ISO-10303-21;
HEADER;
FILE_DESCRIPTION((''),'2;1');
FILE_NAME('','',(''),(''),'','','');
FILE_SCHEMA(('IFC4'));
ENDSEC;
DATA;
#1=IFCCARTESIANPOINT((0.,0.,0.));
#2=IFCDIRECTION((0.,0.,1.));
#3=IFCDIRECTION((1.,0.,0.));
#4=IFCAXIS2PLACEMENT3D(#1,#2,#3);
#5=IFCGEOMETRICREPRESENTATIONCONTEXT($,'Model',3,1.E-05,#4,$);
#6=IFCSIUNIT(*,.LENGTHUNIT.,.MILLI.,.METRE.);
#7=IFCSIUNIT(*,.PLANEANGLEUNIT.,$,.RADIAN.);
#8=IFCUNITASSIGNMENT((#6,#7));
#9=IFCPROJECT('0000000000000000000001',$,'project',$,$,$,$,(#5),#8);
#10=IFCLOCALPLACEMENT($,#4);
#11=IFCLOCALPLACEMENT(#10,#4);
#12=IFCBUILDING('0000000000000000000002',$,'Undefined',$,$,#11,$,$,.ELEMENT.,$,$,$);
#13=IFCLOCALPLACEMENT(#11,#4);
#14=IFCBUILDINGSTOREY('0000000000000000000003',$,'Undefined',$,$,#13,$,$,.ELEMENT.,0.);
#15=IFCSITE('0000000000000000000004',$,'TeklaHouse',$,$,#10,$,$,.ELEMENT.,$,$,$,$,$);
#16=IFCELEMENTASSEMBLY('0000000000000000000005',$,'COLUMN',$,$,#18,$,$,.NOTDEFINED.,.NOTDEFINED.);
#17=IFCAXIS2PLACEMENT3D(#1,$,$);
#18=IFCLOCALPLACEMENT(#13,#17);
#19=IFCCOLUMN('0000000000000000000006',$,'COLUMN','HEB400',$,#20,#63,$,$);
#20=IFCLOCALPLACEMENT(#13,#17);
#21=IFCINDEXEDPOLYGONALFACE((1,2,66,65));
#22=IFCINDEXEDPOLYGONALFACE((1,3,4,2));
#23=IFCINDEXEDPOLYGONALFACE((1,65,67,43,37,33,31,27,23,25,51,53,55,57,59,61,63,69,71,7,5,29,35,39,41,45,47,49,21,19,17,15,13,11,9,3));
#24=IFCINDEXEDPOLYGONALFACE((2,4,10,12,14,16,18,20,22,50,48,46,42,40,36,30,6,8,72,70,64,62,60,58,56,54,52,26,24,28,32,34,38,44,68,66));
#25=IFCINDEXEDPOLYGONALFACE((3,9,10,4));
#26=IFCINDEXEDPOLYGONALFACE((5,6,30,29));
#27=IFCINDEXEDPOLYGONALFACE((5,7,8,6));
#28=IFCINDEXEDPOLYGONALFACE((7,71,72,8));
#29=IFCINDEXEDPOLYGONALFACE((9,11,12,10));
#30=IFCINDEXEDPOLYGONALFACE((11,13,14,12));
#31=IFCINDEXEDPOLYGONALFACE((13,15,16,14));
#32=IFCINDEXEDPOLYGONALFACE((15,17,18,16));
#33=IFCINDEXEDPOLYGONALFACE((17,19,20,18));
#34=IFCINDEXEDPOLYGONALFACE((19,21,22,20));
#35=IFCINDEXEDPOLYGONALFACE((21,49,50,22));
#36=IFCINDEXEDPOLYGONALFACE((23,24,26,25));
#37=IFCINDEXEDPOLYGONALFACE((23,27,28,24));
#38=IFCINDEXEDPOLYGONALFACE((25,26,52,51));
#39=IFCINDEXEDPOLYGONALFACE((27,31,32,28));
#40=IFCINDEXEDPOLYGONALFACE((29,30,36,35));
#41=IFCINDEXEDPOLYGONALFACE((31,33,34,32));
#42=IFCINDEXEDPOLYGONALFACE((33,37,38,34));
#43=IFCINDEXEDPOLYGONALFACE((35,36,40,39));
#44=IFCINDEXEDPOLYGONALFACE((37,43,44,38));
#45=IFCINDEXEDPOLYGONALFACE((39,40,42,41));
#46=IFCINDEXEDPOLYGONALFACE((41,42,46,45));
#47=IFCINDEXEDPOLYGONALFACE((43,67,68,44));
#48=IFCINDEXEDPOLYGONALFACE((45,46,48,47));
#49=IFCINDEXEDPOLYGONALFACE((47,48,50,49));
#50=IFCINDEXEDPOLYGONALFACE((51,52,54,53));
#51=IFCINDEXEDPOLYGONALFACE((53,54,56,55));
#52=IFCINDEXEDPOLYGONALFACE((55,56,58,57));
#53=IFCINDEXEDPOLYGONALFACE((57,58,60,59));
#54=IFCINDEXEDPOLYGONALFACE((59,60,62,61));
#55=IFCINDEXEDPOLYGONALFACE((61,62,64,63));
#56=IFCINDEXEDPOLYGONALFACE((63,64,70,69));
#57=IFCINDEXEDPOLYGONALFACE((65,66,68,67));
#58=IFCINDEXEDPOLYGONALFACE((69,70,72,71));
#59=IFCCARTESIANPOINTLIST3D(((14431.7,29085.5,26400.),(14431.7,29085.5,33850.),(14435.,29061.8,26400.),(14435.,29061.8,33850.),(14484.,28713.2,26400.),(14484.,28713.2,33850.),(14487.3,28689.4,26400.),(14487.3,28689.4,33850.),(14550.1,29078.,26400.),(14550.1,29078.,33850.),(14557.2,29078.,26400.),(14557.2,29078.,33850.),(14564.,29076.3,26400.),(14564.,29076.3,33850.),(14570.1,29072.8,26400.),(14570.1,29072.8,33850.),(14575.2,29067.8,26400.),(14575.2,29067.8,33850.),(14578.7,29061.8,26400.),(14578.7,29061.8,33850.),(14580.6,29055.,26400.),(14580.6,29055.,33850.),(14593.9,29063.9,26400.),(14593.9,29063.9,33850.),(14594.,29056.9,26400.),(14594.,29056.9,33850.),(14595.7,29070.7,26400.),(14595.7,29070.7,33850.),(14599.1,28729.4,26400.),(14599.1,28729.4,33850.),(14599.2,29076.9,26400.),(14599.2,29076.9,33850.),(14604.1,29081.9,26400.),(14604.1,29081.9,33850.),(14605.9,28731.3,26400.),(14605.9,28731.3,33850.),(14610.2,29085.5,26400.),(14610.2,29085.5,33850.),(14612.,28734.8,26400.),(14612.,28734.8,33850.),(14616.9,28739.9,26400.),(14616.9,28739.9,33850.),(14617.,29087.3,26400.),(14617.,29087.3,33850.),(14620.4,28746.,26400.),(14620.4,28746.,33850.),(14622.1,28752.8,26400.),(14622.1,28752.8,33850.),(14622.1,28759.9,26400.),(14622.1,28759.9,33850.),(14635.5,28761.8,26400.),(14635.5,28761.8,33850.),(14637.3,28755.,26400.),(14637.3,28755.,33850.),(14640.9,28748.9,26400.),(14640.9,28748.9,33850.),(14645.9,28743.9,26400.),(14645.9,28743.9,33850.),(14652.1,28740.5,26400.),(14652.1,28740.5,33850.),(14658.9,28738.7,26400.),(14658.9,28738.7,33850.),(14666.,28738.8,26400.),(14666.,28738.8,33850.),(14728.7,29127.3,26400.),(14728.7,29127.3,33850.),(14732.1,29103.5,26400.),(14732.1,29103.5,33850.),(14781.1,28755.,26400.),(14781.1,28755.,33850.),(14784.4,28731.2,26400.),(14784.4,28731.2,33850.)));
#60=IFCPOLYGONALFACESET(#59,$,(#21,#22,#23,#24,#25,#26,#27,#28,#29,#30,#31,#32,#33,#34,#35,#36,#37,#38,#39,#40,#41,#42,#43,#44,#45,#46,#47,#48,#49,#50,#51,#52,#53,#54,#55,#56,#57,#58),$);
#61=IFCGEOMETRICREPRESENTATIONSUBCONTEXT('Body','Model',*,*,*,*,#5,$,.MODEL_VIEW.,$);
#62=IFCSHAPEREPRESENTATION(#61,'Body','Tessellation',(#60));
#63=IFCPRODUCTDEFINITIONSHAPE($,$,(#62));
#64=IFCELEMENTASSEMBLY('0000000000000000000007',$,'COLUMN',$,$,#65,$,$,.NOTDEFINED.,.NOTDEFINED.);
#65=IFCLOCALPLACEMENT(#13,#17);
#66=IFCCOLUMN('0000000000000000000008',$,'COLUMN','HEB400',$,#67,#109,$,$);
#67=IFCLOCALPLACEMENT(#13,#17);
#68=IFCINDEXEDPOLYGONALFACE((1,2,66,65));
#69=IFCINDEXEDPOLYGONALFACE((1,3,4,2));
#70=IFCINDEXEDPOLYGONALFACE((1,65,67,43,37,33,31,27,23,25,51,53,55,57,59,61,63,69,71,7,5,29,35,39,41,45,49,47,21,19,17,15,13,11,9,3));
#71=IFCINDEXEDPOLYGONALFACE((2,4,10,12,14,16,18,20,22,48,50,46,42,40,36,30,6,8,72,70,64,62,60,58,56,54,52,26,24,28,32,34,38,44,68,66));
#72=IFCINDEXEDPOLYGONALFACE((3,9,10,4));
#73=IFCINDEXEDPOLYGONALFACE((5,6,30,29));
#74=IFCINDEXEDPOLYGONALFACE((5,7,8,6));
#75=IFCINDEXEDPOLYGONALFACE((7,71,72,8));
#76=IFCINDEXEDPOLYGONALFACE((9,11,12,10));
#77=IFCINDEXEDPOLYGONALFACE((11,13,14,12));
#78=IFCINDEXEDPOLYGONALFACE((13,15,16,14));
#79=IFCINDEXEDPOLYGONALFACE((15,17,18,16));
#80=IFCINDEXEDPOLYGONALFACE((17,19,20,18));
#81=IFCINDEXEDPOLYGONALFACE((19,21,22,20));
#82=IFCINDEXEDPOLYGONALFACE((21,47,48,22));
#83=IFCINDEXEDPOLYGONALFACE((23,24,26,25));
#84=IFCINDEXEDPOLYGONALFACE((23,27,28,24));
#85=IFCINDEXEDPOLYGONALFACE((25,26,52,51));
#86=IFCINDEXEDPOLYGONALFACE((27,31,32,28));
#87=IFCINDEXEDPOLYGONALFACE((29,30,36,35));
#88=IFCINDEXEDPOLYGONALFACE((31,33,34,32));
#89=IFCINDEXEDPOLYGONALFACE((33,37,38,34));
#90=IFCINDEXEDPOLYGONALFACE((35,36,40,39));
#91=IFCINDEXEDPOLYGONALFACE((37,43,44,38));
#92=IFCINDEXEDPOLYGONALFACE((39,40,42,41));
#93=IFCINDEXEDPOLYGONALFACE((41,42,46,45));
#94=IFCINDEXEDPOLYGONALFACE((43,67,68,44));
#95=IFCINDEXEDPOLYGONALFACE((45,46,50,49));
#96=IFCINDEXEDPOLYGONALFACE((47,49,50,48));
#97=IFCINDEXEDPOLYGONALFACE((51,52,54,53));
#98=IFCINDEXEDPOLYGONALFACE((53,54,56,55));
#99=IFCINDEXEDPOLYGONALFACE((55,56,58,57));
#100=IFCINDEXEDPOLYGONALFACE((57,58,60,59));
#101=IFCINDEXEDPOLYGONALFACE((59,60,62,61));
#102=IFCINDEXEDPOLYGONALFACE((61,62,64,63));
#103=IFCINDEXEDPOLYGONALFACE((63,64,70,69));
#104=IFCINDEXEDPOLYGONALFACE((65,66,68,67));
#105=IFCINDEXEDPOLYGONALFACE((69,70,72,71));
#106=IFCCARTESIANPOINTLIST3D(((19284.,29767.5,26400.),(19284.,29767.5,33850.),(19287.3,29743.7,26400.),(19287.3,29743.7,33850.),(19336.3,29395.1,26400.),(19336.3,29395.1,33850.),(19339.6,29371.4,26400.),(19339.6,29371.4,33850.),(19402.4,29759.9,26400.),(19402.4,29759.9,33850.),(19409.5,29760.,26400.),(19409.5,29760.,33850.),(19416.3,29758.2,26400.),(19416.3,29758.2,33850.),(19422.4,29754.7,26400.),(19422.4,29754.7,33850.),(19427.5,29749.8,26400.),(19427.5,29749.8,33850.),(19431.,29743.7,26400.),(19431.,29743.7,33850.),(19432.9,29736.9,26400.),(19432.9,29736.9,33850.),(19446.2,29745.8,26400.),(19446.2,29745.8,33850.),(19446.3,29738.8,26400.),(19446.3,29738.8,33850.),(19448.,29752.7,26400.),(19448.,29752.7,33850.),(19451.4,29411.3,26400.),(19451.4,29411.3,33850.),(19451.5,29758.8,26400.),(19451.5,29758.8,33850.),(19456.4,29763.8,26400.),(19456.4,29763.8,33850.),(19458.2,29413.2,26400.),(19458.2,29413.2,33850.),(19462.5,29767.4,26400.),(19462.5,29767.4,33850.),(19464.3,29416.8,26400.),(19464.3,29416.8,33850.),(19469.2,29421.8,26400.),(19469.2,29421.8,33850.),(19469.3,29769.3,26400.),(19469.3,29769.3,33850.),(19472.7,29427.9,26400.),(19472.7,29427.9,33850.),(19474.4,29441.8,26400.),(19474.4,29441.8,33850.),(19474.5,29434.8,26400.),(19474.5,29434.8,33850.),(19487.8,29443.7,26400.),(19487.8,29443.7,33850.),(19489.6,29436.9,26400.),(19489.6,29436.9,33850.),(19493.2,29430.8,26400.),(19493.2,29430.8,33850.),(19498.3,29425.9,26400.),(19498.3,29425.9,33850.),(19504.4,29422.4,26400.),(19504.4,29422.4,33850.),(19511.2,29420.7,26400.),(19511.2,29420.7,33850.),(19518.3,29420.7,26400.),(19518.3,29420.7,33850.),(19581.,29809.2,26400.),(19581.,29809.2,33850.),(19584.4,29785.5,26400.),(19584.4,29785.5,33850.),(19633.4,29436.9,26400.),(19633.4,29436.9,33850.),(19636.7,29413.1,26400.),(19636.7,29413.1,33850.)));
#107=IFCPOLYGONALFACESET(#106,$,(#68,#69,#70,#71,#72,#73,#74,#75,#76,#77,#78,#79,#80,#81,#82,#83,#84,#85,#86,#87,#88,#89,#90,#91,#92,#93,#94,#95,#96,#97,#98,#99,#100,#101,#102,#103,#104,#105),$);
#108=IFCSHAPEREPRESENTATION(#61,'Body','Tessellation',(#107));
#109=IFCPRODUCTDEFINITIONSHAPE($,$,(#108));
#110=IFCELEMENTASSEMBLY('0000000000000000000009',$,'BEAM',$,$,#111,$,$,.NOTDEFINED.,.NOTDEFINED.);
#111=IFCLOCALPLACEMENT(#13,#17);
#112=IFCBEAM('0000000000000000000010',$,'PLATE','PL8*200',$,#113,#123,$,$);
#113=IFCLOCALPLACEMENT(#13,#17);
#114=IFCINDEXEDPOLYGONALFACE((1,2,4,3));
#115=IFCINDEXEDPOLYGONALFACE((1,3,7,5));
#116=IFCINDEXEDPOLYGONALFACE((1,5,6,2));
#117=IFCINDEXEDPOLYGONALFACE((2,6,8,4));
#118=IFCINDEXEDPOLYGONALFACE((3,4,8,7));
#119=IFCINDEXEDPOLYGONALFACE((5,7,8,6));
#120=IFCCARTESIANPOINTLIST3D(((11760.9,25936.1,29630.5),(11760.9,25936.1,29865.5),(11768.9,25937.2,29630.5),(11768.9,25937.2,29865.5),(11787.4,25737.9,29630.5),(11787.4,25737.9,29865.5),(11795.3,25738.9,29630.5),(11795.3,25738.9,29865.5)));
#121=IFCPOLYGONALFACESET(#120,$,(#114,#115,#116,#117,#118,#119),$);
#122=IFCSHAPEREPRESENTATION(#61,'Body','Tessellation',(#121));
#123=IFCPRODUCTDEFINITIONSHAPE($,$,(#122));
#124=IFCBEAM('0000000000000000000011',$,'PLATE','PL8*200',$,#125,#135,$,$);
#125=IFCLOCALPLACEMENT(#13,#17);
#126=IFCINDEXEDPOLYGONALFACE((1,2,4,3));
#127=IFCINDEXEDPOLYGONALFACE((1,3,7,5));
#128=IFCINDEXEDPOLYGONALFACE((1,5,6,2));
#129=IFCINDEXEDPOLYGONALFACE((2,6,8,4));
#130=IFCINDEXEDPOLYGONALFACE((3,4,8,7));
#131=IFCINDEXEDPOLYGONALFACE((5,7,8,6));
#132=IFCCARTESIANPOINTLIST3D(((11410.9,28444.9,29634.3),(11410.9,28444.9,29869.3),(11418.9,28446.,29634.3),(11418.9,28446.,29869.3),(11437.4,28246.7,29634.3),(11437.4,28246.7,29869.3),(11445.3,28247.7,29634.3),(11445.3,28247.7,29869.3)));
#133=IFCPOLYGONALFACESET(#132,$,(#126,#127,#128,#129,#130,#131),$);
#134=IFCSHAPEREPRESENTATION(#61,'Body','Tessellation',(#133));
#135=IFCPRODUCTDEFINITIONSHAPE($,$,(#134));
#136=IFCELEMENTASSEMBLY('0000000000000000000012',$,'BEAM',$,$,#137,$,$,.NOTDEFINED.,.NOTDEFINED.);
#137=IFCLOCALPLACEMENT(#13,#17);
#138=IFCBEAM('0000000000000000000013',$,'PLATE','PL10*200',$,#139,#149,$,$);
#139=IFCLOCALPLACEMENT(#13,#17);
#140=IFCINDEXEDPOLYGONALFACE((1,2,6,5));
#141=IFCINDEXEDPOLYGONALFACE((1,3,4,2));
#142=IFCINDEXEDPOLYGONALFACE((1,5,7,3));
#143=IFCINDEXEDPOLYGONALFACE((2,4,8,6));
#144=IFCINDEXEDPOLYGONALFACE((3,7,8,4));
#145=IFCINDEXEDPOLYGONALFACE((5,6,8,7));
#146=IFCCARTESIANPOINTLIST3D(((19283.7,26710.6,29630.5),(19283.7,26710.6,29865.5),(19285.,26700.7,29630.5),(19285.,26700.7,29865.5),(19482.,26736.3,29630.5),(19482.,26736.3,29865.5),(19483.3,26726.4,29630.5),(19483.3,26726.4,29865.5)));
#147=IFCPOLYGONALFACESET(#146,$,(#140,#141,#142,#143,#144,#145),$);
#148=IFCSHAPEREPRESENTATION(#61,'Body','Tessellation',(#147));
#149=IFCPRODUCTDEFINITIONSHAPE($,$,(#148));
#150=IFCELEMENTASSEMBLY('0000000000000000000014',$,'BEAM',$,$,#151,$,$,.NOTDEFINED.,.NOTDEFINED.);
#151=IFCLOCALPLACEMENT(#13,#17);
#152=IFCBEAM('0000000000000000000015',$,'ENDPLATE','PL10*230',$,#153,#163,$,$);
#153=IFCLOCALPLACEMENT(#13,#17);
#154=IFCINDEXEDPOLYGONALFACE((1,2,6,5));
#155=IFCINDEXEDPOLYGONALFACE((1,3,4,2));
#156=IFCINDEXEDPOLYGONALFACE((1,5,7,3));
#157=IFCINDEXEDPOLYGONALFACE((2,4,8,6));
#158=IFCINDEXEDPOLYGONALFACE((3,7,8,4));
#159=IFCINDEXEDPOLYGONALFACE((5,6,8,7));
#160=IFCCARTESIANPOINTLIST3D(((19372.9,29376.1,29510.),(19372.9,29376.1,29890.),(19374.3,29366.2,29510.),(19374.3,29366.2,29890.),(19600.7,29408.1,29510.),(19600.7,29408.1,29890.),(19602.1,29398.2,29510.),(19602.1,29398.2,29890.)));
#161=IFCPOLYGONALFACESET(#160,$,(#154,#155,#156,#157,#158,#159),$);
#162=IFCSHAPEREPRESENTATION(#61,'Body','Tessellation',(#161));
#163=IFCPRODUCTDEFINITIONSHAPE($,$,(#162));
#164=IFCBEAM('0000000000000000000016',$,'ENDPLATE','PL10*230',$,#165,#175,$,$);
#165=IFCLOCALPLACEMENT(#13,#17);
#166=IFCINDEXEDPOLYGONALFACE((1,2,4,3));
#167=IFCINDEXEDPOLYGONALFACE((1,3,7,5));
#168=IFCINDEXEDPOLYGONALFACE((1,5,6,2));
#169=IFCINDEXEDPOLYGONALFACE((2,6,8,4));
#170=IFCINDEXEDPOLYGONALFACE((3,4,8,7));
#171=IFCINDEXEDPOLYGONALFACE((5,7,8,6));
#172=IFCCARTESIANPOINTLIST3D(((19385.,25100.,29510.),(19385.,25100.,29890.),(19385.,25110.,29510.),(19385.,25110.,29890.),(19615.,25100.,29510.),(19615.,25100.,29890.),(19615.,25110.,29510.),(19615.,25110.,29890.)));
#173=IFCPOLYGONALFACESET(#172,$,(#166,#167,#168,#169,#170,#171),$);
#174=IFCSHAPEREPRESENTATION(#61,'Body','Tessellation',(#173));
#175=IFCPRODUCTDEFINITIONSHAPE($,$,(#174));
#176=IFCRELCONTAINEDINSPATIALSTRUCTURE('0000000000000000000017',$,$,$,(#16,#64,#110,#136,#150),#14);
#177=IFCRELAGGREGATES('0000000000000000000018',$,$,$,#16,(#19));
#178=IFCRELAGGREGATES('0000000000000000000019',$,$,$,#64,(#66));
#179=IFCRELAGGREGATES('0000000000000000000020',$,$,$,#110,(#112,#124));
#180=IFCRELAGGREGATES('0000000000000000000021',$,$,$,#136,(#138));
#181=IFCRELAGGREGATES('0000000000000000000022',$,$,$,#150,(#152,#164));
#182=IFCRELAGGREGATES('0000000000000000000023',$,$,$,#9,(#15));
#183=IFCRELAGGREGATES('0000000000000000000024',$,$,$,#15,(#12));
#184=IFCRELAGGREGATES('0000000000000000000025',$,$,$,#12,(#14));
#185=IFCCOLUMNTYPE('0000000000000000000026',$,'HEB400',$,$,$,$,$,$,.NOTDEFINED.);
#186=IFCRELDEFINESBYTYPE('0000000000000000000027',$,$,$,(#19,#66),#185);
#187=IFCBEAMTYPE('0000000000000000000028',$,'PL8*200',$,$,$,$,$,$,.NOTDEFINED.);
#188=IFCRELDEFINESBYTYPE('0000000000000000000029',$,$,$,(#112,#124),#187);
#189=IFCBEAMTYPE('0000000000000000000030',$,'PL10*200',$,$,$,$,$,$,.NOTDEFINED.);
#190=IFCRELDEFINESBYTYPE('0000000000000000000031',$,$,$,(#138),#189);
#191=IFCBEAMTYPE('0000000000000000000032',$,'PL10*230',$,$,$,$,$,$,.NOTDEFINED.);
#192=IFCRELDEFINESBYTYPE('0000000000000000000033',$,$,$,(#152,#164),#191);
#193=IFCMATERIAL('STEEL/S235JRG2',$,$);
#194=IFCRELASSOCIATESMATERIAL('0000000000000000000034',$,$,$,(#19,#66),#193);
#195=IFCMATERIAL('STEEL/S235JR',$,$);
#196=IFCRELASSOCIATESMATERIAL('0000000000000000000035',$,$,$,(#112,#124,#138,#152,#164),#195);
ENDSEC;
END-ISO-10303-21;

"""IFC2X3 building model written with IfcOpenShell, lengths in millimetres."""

from ifc_helpers import new_model, si_unit, frame, origin_with_axes, origin_2d_with_axis, place, context, subcontext, project, spatial, rectangle, i_section, extrude, material, type_object, element, aggregate, save


model = new_model("IFC2X3")

# Units and contexts
model_context = context("Model", 3, precision=1e-05, world=origin_with_axes())
body_context = subcontext(model_context, "Body", "Model", "MODEL_VIEW")
ifc_project = project(units=[si_unit("LENGTHUNIT", "METRE", prefix="MILLI"), si_unit("PLANEANGLEUNIT", "RADIAN")], contexts=[model_context])

# Site, building, storey
site_placement = place(None, origin_with_axes())
site = spatial("IfcSite", under=ifc_project, at=site_placement, Name="TeklaHouse", CompositionType="ELEMENT")
building_placement = place(site_placement, origin_with_axes())
building = spatial("IfcBuilding", under=site, at=building_placement, Name="Undefined", CompositionType="ELEMENT")
storey_placement = place(building_placement, origin_with_axes())
storey = spatial("IfcBuildingStorey", under=building, at=storey_placement, Name="Undefined", CompositionType="ELEMENT", Elevation=0.0)

# Element assemblies, columns
assembly_1_placement = place(storey_placement, origin_with_axes())
assembly_1 = element("IfcElementAssembly", 1, at=assembly_1_placement, inside=storey, Name="COLUMN", AssemblyPlace="NOTDEFINED", PredefinedType="NOTDEFINED")
ifc_material_1 = material(Name="STEEL/S235JRG2")
column_type = type_object("IfcColumnType", Name="HEB400", PredefinedType="NOTDEFINED")
column_1_placement = place(assembly_1_placement, frame((14608.0, 28908.4, 26400.0), z_axis=(0.0, 0.0, 1.0), x_axis=(-0.139174, 0.990268, 0.0)))
column_1 = element("IfcColumn", 2, at=column_1_placement, type_object=column_type, material=ifc_material_1, Name="COLUMN", Description="HEB400", context=body_context, shape_type="SweptSolid", body=[
    extrude(i_section(OverallWidth=300.0, OverallDepth=400.0, WebThickness=13.5, FlangeThickness=24.0, FilletRadius=27.0, at=origin_2d_with_axis()), frame((0.0, 0.0, 7450.0), z_axis=(0.0, 0.0, -1.0), x_axis=(0.0, 1.0, 0.0)), (0.0, 0.0, 1.0), 7450.0),
])
aggregate(assembly_1, [column_1])
assembly_2_placement = place(storey_placement, origin_with_axes())
assembly_2 = element("IfcElementAssembly", 3, at=assembly_2_placement, inside=storey, Name="COLUMN", AssemblyPlace="NOTDEFINED", PredefinedType="NOTDEFINED")
column_2_placement = place(assembly_2_placement, frame((19460.3, 29590.3, 26400.0), z_axis=(0.0, 0.0, 1.0), x_axis=(-0.139174, 0.990268, 0.0)))
column_2 = element("IfcColumn", 4, at=column_2_placement, type_object=column_type, material=ifc_material_1, Name="COLUMN", Description="HEB400", context=body_context, shape_type="SweptSolid", body=[
    extrude(i_section(OverallWidth=300.0, OverallDepth=400.0, WebThickness=13.5, FlangeThickness=24.0, FilletRadius=27.0, at=origin_2d_with_axis()), frame((0.0, 0.0, 7450.0), z_axis=(0.0, 0.0, -1.0), x_axis=(0.0, 1.0, 0.0)), (0.0, 0.0, 1.0), 7450.0),
])

# Element assembly, beams
assembly_3_placement = place(storey_placement, origin_with_axes())
assembly_3 = element("IfcElementAssembly", 5, at=assembly_3_placement, inside=storey, Name="BEAM", AssemblyPlace="NOTDEFINED", PredefinedType="NOTDEFINED")
ifc_material_2 = material(Name="STEEL/S235JR")
beam_type_1 = type_object("IfcBeamType", Name="PL8*200", PredefinedType="NOTDEFINED")
beam_1_placement = place(assembly_3_placement, frame((11778.1, 25837.5, 29630.5), z_axis=(0.132256, -0.991216, 0.0), x_axis=(0.0, 0.0, 1.0)))
beam_1 = element("IfcBeam", 6, at=beam_1_placement, type_object=beam_type_1, material=ifc_material_2, Name="PLATE", Description="PL8*200", context=body_context, shape_type="SweptSolid", body=[
    extrude(rectangle(XDim=8.0, YDim=200.0, at=origin_2d_with_axis()), frame((235.0, 0.0, 0.0), z_axis=(-1.0, 0.0, 0.0), x_axis=(0.0, -1.0, 0.0)), (0.0, 0.0, 1.0), 235.0),
])
beam_2_placement = place(assembly_3_placement, frame((11428.1, 28346.3, 29634.3), z_axis=(-0.132256, 0.991216, 0.0), x_axis=(0.0, 0.0, 1.0)))
beam_2 = element("IfcBeam", 7, at=beam_2_placement, type_object=beam_type_1, material=ifc_material_2, Name="PLATE", Description="PL8*200", context=body_context, shape_type="SweptSolid", body=[
    extrude(rectangle(XDim=8.0, YDim=200.0, at=origin_2d_with_axis()), frame((235.0, 0.0, 0.0), z_axis=(-1.0, 0.0, 0.0), x_axis=(0.0, -1.0, 0.0)), (0.0, 0.0, 1.0), 235.0),
])

# Element assembly, beam
assembly_4_placement = place(storey_placement, origin_with_axes())
assembly_4 = element("IfcElementAssembly", 8, at=assembly_4_placement, inside=storey, Name="BEAM", AssemblyPlace="NOTDEFINED", PredefinedType="NOTDEFINED")
beam_type_2 = type_object("IfcBeamType", Name="PL10*200", PredefinedType="NOTDEFINED")
beam_3_placement = place(assembly_4_placement, frame((19383.5, 26718.5, 29630.5), z_axis=(0.991687, 0.128673, 0.0), x_axis=(0.0, 0.0, 1.0)))
beam_3 = element("IfcBeam", 9, at=beam_3_placement, type_object=beam_type_2, material=ifc_material_2, Name="PLATE", Description="PL10*200", context=body_context, shape_type="SweptSolid", body=[
    extrude(rectangle(XDim=10.0, YDim=200.0, at=origin_2d_with_axis()), frame((235.0, 0.0, 0.0), z_axis=(-1.0, 0.0, 0.0), x_axis=(0.0, -1.0, 0.0)), (0.0, 0.0, 1.0), 235.0),
])

# Element assembly, beams
assembly_5_placement = place(storey_placement, origin_with_axes())
assembly_5 = element("IfcElementAssembly", 10, at=assembly_5_placement, inside=storey, Name="BEAM", AssemblyPlace="NOTDEFINED", PredefinedType="NOTDEFINED")
beam_type_3 = type_object("IfcBeamType", Name="PL10*230", PredefinedType="NOTDEFINED")
beam_4_placement = place(assembly_5_placement, frame((19487.5, 29387.1, 29510.0), z_axis=(-0.990268, -0.139173, 0.0), x_axis=(0.0, 0.0, 1.0)))
beam_4 = element("IfcBeam", 11, at=beam_4_placement, type_object=beam_type_3, material=ifc_material_2, Name="ENDPLATE", Description="PL10*230", context=body_context, shape_type="SweptSolid", body=[
    extrude(rectangle(XDim=10.0, YDim=230.0, at=origin_2d_with_axis()), frame((380.0, 0.0, 0.0), z_axis=(-1.0, 0.0, 0.0), x_axis=(0.0, -1.0, 0.0)), (0.0, 0.0, 1.0), 380.0),
])
beam_5_placement = place(assembly_5_placement, frame((19500.0, 25105.0, 29510.0), z_axis=(1.0, 0.0, 0.0), x_axis=(0.0, 0.0, 1.0)))
beam_5 = element("IfcBeam", 12, at=beam_5_placement, type_object=beam_type_3, material=ifc_material_2, Name="ENDPLATE", Description="PL10*230", context=body_context, shape_type="SweptSolid", body=[
    extrude(rectangle(XDim=10.0, YDim=230.0, at=origin_2d_with_axis()), frame((380.0, 0.0, 0.0), z_axis=(-1.0, 0.0, 0.0), x_axis=(0.0, -1.0, 0.0)), (0.0, 0.0, 1.0), 380.0),
])

aggregate(assembly_2, [column_2])

aggregate(assembly_3, [beam_1, beam_2])

aggregate(assembly_4, [beam_3])

aggregate(assembly_5, [beam_4, beam_5])

save(model, "model.ifc")
